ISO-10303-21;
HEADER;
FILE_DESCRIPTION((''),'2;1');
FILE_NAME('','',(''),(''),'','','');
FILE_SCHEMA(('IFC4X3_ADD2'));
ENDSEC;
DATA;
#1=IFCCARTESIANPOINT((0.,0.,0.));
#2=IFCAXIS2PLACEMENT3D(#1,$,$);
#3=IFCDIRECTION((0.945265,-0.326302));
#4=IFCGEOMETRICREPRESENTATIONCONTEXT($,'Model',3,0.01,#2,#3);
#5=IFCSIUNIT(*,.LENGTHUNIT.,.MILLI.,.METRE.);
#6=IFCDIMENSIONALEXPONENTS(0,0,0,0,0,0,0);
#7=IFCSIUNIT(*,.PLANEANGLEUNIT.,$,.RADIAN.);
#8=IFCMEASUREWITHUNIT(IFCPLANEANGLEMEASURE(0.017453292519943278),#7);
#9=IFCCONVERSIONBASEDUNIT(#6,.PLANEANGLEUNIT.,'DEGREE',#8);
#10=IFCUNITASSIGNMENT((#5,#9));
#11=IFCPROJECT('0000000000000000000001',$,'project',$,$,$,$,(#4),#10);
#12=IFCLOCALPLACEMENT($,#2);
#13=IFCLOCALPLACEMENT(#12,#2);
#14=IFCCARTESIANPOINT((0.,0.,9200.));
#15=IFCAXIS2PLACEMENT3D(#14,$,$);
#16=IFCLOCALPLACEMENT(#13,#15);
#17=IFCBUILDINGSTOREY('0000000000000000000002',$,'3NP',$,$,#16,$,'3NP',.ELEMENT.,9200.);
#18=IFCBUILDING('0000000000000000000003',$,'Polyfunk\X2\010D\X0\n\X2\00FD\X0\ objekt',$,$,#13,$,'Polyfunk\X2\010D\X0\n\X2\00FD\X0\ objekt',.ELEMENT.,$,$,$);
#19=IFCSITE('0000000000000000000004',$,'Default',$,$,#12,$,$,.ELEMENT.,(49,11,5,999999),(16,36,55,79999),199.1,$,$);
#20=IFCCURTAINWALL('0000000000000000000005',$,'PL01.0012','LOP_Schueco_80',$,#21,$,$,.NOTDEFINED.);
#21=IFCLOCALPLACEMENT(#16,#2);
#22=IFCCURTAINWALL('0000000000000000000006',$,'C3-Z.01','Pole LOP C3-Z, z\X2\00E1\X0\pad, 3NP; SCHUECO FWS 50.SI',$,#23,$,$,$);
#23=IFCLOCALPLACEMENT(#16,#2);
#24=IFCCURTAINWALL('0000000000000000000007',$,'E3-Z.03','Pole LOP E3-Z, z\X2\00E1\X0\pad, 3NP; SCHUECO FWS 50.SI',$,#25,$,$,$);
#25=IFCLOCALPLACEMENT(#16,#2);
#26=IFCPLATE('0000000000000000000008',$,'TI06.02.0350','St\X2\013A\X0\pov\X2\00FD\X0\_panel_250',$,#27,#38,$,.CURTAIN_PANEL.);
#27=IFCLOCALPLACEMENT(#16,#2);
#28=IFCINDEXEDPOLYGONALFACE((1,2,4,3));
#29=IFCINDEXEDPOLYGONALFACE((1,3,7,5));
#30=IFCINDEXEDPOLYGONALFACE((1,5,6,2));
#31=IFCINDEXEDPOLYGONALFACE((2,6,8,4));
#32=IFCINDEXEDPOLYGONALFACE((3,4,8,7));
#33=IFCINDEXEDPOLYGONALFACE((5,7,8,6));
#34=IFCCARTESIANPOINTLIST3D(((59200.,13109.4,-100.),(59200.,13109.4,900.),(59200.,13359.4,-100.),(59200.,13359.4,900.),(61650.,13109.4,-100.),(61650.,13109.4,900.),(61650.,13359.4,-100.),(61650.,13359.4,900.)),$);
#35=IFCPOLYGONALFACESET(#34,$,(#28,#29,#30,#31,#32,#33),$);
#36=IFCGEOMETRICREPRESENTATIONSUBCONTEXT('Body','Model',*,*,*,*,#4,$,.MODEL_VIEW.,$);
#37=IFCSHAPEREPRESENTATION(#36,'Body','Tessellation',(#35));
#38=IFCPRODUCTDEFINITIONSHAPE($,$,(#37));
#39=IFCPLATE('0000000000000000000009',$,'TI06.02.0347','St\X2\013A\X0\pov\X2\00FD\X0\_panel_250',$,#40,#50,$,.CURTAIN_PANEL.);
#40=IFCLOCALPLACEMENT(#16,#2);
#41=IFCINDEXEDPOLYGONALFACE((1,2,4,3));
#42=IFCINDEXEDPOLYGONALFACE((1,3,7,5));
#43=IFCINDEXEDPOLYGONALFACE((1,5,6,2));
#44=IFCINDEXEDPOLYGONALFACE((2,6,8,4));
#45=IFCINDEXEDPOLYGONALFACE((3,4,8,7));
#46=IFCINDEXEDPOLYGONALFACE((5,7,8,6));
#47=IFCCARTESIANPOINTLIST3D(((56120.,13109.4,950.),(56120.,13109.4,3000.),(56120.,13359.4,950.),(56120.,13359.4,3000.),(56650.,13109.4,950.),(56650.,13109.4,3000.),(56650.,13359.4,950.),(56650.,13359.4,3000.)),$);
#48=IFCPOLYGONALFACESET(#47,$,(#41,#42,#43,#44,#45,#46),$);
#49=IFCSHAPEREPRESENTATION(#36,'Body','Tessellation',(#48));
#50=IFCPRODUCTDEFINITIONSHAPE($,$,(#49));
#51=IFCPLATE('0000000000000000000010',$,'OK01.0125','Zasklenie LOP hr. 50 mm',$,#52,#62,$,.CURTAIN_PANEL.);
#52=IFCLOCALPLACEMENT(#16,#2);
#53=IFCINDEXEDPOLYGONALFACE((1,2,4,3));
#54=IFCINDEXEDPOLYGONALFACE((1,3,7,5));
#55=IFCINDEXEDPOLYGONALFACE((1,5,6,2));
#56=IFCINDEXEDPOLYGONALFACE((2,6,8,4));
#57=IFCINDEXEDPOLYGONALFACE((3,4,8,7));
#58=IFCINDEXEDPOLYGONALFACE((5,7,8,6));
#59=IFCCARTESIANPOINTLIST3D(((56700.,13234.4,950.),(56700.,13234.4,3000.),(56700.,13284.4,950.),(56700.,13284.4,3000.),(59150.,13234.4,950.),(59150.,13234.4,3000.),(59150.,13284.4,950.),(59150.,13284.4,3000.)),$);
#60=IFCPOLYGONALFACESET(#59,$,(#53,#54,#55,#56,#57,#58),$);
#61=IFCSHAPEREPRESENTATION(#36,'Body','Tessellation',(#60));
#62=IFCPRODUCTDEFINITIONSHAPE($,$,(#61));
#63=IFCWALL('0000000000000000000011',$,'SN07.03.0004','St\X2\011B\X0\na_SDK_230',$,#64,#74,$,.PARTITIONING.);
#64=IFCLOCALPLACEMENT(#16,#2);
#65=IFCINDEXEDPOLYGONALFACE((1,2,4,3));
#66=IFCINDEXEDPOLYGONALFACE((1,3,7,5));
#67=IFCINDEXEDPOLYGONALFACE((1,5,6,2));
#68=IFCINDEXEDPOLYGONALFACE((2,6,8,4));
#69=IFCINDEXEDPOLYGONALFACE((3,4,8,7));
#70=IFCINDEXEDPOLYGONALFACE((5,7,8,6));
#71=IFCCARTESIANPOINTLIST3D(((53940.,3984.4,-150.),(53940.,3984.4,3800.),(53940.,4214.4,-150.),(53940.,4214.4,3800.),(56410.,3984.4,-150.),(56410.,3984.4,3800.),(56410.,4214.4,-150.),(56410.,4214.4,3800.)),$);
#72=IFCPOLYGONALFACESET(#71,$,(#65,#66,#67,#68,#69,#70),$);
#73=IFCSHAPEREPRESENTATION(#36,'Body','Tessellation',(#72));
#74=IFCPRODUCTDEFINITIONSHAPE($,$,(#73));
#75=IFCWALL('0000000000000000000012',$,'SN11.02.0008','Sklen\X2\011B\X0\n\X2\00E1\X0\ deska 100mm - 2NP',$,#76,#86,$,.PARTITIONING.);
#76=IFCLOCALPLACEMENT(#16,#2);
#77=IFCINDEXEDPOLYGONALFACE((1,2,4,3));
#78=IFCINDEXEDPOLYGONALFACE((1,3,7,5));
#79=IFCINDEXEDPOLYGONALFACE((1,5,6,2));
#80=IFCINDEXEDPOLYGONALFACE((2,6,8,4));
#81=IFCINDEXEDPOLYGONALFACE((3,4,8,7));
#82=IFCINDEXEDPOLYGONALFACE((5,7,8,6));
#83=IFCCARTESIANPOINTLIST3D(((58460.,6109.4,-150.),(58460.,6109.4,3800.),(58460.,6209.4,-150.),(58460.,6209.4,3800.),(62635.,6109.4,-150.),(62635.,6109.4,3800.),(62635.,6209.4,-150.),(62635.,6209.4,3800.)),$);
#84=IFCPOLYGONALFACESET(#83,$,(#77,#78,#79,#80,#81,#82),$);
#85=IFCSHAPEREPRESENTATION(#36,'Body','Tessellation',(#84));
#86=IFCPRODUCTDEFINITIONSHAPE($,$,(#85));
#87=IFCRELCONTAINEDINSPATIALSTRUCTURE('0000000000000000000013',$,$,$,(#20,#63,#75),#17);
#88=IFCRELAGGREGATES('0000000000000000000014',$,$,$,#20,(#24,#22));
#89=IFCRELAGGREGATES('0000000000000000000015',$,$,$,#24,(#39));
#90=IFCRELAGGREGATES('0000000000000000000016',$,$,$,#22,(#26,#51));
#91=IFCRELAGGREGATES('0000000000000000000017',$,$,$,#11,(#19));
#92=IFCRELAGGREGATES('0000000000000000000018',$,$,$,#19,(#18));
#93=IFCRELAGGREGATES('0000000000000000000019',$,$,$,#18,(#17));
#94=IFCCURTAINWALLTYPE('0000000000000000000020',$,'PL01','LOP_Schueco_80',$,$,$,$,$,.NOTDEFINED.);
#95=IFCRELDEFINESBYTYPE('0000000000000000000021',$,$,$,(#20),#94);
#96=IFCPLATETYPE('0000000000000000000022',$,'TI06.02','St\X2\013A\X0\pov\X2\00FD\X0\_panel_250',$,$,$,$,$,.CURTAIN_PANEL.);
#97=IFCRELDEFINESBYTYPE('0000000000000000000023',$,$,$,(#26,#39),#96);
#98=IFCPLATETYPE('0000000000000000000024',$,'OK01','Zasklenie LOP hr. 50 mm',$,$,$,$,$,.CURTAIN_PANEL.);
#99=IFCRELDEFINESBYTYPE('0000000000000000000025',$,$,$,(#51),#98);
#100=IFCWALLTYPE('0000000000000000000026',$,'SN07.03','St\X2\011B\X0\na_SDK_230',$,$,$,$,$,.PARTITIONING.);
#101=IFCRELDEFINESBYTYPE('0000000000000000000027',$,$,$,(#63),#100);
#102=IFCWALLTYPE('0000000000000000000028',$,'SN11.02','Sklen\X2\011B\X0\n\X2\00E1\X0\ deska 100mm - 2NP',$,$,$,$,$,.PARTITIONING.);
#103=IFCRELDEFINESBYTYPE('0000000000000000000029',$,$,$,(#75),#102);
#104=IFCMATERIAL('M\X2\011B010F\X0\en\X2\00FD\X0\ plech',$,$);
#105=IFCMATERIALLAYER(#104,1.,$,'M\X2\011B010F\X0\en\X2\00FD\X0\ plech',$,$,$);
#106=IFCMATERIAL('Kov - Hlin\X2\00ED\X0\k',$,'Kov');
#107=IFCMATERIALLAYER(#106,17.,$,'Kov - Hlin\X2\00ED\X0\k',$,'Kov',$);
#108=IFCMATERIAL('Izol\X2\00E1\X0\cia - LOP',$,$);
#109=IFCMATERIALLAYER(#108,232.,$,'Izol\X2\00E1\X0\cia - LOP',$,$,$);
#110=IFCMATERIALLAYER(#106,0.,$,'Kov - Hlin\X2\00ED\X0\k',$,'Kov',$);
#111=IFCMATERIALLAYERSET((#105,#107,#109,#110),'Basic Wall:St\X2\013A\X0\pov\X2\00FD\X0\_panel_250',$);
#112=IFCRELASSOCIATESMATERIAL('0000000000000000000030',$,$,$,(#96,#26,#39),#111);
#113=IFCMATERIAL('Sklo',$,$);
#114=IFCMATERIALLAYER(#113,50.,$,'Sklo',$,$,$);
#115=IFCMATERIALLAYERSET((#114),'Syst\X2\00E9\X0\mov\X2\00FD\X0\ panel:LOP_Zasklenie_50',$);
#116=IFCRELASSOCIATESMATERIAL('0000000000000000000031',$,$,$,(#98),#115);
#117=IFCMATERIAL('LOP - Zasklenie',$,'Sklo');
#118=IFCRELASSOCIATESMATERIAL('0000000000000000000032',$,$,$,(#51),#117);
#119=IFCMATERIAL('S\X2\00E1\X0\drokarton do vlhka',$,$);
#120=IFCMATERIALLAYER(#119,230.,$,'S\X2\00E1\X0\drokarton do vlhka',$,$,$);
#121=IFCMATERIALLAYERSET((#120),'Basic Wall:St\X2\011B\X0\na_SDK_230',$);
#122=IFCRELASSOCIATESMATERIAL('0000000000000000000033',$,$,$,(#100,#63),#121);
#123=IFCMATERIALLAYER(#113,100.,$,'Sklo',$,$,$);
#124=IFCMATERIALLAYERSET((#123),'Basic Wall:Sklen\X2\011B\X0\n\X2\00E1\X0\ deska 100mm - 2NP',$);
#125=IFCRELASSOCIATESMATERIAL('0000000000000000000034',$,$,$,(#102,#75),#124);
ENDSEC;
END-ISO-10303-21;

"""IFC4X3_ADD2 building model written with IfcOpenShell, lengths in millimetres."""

from ifc_helpers import new_model, entity, si_unit, converted_unit, direction, frame, frame_2d, origin, origin_2d_with_axis, place, context, subcontext, project, spatial, polyline, rectangle, extrude, clip, bounded_halfspace, source, transform, mapped, material, layer, layer_set, layer_usage, type_object, type_shapes, element, aggregate, save


model = new_model("IFC4X3_ADD2")

# Units and contexts
model_context = context("Model", 3, precision=0.01, world=origin(), true_north=direction((0.945265, -0.326302)))
body_context = subcontext(model_context, "Body", "Model", "MODEL_VIEW")
ifc_project = project(units=[si_unit("LENGTHUNIT", "METRE", prefix="MILLI"), converted_unit("PLANEANGLEUNIT", "DEGREE", entity("IfcPlaneAngleMeasure", 0.017453292519943278), si_unit("PLANEANGLEUNIT", "RADIAN"), dimensions=[0, 0, 0, 0, 0, 0, 0])], contexts=[model_context])

# Site, building, storey
site_placement = place(None, origin())
site = spatial("IfcSite", under=ifc_project, at=site_placement, Name="Default", CompositionType="ELEMENT", RefLatitude=(49, 11, 5, 999999), RefLongitude=(16, 36, 55, 79999), RefElevation=199.1)
building_placement = place(site_placement, origin())
building = spatial("IfcBuilding", under=site, at=building_placement, Name="Polyfunkčný objekt", LongName="Polyfunkčný objekt", CompositionType="ELEMENT")
storey_placement = place(building_placement, frame((0.0, 0.0, 9200.0)))
storey = spatial("IfcBuildingStorey", under=building, at=storey_placement, Name="3NP", LongName="3NP", CompositionType="ELEMENT", Elevation=9200.0)

# Curtain walls, plates
curtain_wall_type = type_object("IfcCurtainWallType", Name="PL01", Description="LOP_Schueco_80", PredefinedType="NOTDEFINED")
curtain_wall_1_placement = place(storey_placement, frame((0.0, 0.0, -9200.0)))
curtain_wall_1 = element("IfcCurtainWall", 1, at=curtain_wall_1_placement, inside=storey, type_object=curtain_wall_type, Name="PL01.0012", Description="LOP_Schueco_80", PredefinedType="NOTDEFINED")
curtain_wall_2 = element("IfcCurtainWall", 2, Name="C3-Z.01", Description="Pole LOP C3-Z, západ, 3NP; SCHUECO FWS 50.SI")
curtain_wall_3 = element("IfcCurtainWall", 3, Name="E3-Z.03", Description="Pole LOP E3-Z, západ, 3NP; SCHUECO FWS 50.SI")
aggregate(curtain_wall_1, [curtain_wall_3, curtain_wall_2])
ifc_material_1 = material(Name="Měďený plech")
ifc_layer_1 = layer(ifc_material_1, 1.0, Name="Měďený plech")
ifc_material_2 = material(Name="Kov - Hliník", Category="Kov")
ifc_layer_2 = layer(ifc_material_2, 17.0, Name="Kov - Hliník", Category="Kov")
ifc_material_3 = material(Name="Izolácia - LOP")
ifc_layer_3 = layer(ifc_material_3, 232.0, Name="Izolácia - LOP")
ifc_layer_4 = layer(ifc_material_2, 0.0, Name="Kov - Hliník", Category="Kov")
ifc_layer_set_1 = layer_set([ifc_layer_1, ifc_layer_2, ifc_layer_3, ifc_layer_4], Name="Basic Wall:Stĺpový_panel_250")
ifc_layer_usage_1 = layer_usage(ifc_layer_set_1, "AXIS2", "NEGATIVE", 125.0)
plate_type_1 = type_object("IfcPlateType", Name="TI06.02", Description="Stĺpový_panel_250", PredefinedType="CURTAIN_PANEL", material=ifc_layer_set_1)
plate_1_placement = place(storey_placement, frame((59200.0, 13234.4, -100.0)))
plate_1 = element("IfcPlate", 4, at=plate_1_placement, type_object=plate_type_1, material=ifc_layer_usage_1, Name="TI06.02.0350", Description="Stĺpový_panel_250", PredefinedType="CURTAIN_PANEL", context=body_context, shape_type="SweptSolid", body=[
    extrude(rectangle(XDim=250.0, YDim=2450.0, at=frame_2d((0.0, 0.0), x_axis=(1.0, 0.0))), frame((1225.0, 0.0, 0.0), z_axis=(0.0, 0.0, 1.0), x_axis=(0.0, 1.0, 0.0)), (0.0, 0.0, 1.0), 1000.0),
])
ifc_layer_usage_2 = layer_usage(ifc_layer_set_1, "AXIS2", "NEGATIVE", 125.0)
plate_2_placement = place(storey_placement, frame((56120.0, 13234.4, 950.0)))
plate_2 = element("IfcPlate", 5, at=plate_2_placement, type_object=plate_type_1, material=ifc_layer_usage_2, Name="TI06.02.0347", Description="Stĺpový_panel_250", PredefinedType="CURTAIN_PANEL", context=body_context, shape_type="SweptSolid", body=[
    extrude(rectangle(XDim=250.0, YDim=530.0, at=frame_2d((0.0, 0.0), x_axis=(1.0, 0.0))), frame((265.0, 0.0, 0.0), z_axis=(0.0, 0.0, 1.0), x_axis=(0.0, 1.0, 0.0)), (0.0, 0.0, 1.0), 2050.0),
])
aggregate(curtain_wall_3, [plate_2])
ifc_material_4 = material(Name="LOP - Zasklenie", Category="Sklo")
ifc_material_5 = material(Name="Sklo")
ifc_layer_5 = layer(ifc_material_5, 50.0, Name="Sklo")
ifc_layer_set_2 = layer_set([ifc_layer_5], Name="Systémový panel:LOP_Zasklenie_50")
plate_type_2 = type_object("IfcPlateType", Name="OK01", Description="Zasklenie LOP hr. 50 mm", PredefinedType="CURTAIN_PANEL", material=ifc_layer_set_2)
shared_shape_1 = source(origin(), body_context, "Body", "SweptSolid", [
    extrude(rectangle(XDim=50.0, YDim=2450.0, at=origin_2d_with_axis()), frame((0.0, 25.0, 0.0), z_axis=(0.0, 0.0, 1.0), x_axis=(0.0, 1.0, 0.0)), (0.0, 0.0, 1.0), 2050.0),
])
type_shapes(plate_type_2, [shared_shape_1])
plate_3_placement = place(curtain_wall_1_placement, frame((57925.0, 13234.4, 10150.0)))
plate_3 = element("IfcPlate", 6, at=plate_3_placement, type_object=plate_type_2, material=ifc_material_4, Name="OK01.0125", Description="Zasklenie LOP hr. 50 mm", PredefinedType="CURTAIN_PANEL", context=body_context, shape_type="MappedRepresentation", body=[
    mapped(shared_shape_1, transform((0.0, 0.0, 0.0), scale=1.0)),
])
aggregate(curtain_wall_2, [plate_1, plate_3])

# Walls
ifc_material_6 = material(Name="Sádrokarton do vlhka")
ifc_layer_6 = layer(ifc_material_6, 230.0, Name="Sádrokarton do vlhka")
ifc_layer_set_3 = layer_set([ifc_layer_6], Name="Basic Wall:Stěna_SDK_230")
wall_type_1 = type_object("IfcWallType", Name="SN07.03", Description="Stěna_SDK_230", PredefinedType="PARTITIONING", material=ifc_layer_set_3)
placement = place(building_placement, frame((0.0, 0.0, 5000.0)))
wall_1_placement = place(placement, frame((56410.0, 4099.4, 4050.0), z_axis=(0.0, 0.0, 1.0), x_axis=(-1.0, 0.0, 0.0)))
element("IfcWall", 7, at=wall_1_placement, inside=storey, type_object=wall_type_1, material=ifc_layer_set_3, Name="SN07.03.0004", Description="Stěna_SDK_230", PredefinedType="PARTITIONING", context=body_context, shape_type="Clipping", body=[
    clip(clip(extrude(rectangle(XDim=2470.0, YDim=230.0, at=frame_2d((1235.0, 0.0), x_axis=(-1.0, 0.0))), origin(), (0.0, 0.0, 1.0), 3950.0), bounded_halfspace(frame((2470.0, -115.0, 0.0)), True, frame((2470.0, -115.0, 0.0)), polyline([(0.0, 0.0), (0.0, 60.0), (0.0, 230.0), (-320.0, 230.0), (-2470.0, 230.0), (-2470.0, 0.0), (-150.0, 0.0), (0.0, 0.0)]))), bounded_halfspace(frame((0.0, -115.0, 3950.0), z_axis=(0.0, 0.0, -1.0), x_axis=(-1.0, 0.0, 0.0)), True, frame((0.0, -115.0, 3950.0)), polyline([(0.0, 0.0), (2320.0, 0.0), (2470.0, 0.0), (2470.0, 60.0), (2470.0, 230.0), (2150.0, 230.0), (0.0, 230.0), (0.0, 0.0)]))),
])
ifc_layer_7 = layer(ifc_material_5, 100.0, Name="Sklo")
ifc_layer_set_4 = layer_set([ifc_layer_7], Name="Basic Wall:Skleněná deska 100mm - 2NP")
wall_type_2 = type_object("IfcWallType", Name="SN11.02", Description="Skleněná deska 100mm - 2NP", PredefinedType="PARTITIONING", material=ifc_layer_set_4)
wall_2_placement = place(placement, frame((58460.0, 6159.4, 4050.0)))
element("IfcWall", 8, at=wall_2_placement, inside=storey, type_object=wall_type_2, material=ifc_layer_set_4, Name="SN11.02.0008", Description="Skleněná deska 100mm - 2NP", PredefinedType="PARTITIONING", context=body_context, shape_type="Clipping", body=[
    clip(clip(extrude(rectangle(XDim=4175.0, YDim=100.0, at=frame_2d((2087.5, 0.0), x_axis=(-1.0, 0.0))), origin(), (0.0, 0.0, 1.0), 3950.0), bounded_halfspace(frame((4175.0, -50.0, 0.0), z_axis=(0.0, 0.0, 1.0), x_axis=(-1.0, 0.0, 0.0)), True, frame((4175.0, -50.0, 0.0)), polyline([(0.0, 0.0), (0.0, 100.0), (-4175.0, 100.0), (-4175.0, 0.0), (-4075.0, 0.0), (0.0, 0.0)]))), bounded_halfspace(frame((0.0, -50.0, 3950.0), z_axis=(0.0, 0.0, -1.0), x_axis=(1.0, 0.0, 0.0)), True, frame((0.0, -50.0, 3950.0)), polyline([(0.0, 0.0), (100.0, 0.0), (4175.0, 0.0), (4175.0, 100.0), (0.0, 100.0), (0.0, 0.0)]))),
])

save(model, "model.ifc")
